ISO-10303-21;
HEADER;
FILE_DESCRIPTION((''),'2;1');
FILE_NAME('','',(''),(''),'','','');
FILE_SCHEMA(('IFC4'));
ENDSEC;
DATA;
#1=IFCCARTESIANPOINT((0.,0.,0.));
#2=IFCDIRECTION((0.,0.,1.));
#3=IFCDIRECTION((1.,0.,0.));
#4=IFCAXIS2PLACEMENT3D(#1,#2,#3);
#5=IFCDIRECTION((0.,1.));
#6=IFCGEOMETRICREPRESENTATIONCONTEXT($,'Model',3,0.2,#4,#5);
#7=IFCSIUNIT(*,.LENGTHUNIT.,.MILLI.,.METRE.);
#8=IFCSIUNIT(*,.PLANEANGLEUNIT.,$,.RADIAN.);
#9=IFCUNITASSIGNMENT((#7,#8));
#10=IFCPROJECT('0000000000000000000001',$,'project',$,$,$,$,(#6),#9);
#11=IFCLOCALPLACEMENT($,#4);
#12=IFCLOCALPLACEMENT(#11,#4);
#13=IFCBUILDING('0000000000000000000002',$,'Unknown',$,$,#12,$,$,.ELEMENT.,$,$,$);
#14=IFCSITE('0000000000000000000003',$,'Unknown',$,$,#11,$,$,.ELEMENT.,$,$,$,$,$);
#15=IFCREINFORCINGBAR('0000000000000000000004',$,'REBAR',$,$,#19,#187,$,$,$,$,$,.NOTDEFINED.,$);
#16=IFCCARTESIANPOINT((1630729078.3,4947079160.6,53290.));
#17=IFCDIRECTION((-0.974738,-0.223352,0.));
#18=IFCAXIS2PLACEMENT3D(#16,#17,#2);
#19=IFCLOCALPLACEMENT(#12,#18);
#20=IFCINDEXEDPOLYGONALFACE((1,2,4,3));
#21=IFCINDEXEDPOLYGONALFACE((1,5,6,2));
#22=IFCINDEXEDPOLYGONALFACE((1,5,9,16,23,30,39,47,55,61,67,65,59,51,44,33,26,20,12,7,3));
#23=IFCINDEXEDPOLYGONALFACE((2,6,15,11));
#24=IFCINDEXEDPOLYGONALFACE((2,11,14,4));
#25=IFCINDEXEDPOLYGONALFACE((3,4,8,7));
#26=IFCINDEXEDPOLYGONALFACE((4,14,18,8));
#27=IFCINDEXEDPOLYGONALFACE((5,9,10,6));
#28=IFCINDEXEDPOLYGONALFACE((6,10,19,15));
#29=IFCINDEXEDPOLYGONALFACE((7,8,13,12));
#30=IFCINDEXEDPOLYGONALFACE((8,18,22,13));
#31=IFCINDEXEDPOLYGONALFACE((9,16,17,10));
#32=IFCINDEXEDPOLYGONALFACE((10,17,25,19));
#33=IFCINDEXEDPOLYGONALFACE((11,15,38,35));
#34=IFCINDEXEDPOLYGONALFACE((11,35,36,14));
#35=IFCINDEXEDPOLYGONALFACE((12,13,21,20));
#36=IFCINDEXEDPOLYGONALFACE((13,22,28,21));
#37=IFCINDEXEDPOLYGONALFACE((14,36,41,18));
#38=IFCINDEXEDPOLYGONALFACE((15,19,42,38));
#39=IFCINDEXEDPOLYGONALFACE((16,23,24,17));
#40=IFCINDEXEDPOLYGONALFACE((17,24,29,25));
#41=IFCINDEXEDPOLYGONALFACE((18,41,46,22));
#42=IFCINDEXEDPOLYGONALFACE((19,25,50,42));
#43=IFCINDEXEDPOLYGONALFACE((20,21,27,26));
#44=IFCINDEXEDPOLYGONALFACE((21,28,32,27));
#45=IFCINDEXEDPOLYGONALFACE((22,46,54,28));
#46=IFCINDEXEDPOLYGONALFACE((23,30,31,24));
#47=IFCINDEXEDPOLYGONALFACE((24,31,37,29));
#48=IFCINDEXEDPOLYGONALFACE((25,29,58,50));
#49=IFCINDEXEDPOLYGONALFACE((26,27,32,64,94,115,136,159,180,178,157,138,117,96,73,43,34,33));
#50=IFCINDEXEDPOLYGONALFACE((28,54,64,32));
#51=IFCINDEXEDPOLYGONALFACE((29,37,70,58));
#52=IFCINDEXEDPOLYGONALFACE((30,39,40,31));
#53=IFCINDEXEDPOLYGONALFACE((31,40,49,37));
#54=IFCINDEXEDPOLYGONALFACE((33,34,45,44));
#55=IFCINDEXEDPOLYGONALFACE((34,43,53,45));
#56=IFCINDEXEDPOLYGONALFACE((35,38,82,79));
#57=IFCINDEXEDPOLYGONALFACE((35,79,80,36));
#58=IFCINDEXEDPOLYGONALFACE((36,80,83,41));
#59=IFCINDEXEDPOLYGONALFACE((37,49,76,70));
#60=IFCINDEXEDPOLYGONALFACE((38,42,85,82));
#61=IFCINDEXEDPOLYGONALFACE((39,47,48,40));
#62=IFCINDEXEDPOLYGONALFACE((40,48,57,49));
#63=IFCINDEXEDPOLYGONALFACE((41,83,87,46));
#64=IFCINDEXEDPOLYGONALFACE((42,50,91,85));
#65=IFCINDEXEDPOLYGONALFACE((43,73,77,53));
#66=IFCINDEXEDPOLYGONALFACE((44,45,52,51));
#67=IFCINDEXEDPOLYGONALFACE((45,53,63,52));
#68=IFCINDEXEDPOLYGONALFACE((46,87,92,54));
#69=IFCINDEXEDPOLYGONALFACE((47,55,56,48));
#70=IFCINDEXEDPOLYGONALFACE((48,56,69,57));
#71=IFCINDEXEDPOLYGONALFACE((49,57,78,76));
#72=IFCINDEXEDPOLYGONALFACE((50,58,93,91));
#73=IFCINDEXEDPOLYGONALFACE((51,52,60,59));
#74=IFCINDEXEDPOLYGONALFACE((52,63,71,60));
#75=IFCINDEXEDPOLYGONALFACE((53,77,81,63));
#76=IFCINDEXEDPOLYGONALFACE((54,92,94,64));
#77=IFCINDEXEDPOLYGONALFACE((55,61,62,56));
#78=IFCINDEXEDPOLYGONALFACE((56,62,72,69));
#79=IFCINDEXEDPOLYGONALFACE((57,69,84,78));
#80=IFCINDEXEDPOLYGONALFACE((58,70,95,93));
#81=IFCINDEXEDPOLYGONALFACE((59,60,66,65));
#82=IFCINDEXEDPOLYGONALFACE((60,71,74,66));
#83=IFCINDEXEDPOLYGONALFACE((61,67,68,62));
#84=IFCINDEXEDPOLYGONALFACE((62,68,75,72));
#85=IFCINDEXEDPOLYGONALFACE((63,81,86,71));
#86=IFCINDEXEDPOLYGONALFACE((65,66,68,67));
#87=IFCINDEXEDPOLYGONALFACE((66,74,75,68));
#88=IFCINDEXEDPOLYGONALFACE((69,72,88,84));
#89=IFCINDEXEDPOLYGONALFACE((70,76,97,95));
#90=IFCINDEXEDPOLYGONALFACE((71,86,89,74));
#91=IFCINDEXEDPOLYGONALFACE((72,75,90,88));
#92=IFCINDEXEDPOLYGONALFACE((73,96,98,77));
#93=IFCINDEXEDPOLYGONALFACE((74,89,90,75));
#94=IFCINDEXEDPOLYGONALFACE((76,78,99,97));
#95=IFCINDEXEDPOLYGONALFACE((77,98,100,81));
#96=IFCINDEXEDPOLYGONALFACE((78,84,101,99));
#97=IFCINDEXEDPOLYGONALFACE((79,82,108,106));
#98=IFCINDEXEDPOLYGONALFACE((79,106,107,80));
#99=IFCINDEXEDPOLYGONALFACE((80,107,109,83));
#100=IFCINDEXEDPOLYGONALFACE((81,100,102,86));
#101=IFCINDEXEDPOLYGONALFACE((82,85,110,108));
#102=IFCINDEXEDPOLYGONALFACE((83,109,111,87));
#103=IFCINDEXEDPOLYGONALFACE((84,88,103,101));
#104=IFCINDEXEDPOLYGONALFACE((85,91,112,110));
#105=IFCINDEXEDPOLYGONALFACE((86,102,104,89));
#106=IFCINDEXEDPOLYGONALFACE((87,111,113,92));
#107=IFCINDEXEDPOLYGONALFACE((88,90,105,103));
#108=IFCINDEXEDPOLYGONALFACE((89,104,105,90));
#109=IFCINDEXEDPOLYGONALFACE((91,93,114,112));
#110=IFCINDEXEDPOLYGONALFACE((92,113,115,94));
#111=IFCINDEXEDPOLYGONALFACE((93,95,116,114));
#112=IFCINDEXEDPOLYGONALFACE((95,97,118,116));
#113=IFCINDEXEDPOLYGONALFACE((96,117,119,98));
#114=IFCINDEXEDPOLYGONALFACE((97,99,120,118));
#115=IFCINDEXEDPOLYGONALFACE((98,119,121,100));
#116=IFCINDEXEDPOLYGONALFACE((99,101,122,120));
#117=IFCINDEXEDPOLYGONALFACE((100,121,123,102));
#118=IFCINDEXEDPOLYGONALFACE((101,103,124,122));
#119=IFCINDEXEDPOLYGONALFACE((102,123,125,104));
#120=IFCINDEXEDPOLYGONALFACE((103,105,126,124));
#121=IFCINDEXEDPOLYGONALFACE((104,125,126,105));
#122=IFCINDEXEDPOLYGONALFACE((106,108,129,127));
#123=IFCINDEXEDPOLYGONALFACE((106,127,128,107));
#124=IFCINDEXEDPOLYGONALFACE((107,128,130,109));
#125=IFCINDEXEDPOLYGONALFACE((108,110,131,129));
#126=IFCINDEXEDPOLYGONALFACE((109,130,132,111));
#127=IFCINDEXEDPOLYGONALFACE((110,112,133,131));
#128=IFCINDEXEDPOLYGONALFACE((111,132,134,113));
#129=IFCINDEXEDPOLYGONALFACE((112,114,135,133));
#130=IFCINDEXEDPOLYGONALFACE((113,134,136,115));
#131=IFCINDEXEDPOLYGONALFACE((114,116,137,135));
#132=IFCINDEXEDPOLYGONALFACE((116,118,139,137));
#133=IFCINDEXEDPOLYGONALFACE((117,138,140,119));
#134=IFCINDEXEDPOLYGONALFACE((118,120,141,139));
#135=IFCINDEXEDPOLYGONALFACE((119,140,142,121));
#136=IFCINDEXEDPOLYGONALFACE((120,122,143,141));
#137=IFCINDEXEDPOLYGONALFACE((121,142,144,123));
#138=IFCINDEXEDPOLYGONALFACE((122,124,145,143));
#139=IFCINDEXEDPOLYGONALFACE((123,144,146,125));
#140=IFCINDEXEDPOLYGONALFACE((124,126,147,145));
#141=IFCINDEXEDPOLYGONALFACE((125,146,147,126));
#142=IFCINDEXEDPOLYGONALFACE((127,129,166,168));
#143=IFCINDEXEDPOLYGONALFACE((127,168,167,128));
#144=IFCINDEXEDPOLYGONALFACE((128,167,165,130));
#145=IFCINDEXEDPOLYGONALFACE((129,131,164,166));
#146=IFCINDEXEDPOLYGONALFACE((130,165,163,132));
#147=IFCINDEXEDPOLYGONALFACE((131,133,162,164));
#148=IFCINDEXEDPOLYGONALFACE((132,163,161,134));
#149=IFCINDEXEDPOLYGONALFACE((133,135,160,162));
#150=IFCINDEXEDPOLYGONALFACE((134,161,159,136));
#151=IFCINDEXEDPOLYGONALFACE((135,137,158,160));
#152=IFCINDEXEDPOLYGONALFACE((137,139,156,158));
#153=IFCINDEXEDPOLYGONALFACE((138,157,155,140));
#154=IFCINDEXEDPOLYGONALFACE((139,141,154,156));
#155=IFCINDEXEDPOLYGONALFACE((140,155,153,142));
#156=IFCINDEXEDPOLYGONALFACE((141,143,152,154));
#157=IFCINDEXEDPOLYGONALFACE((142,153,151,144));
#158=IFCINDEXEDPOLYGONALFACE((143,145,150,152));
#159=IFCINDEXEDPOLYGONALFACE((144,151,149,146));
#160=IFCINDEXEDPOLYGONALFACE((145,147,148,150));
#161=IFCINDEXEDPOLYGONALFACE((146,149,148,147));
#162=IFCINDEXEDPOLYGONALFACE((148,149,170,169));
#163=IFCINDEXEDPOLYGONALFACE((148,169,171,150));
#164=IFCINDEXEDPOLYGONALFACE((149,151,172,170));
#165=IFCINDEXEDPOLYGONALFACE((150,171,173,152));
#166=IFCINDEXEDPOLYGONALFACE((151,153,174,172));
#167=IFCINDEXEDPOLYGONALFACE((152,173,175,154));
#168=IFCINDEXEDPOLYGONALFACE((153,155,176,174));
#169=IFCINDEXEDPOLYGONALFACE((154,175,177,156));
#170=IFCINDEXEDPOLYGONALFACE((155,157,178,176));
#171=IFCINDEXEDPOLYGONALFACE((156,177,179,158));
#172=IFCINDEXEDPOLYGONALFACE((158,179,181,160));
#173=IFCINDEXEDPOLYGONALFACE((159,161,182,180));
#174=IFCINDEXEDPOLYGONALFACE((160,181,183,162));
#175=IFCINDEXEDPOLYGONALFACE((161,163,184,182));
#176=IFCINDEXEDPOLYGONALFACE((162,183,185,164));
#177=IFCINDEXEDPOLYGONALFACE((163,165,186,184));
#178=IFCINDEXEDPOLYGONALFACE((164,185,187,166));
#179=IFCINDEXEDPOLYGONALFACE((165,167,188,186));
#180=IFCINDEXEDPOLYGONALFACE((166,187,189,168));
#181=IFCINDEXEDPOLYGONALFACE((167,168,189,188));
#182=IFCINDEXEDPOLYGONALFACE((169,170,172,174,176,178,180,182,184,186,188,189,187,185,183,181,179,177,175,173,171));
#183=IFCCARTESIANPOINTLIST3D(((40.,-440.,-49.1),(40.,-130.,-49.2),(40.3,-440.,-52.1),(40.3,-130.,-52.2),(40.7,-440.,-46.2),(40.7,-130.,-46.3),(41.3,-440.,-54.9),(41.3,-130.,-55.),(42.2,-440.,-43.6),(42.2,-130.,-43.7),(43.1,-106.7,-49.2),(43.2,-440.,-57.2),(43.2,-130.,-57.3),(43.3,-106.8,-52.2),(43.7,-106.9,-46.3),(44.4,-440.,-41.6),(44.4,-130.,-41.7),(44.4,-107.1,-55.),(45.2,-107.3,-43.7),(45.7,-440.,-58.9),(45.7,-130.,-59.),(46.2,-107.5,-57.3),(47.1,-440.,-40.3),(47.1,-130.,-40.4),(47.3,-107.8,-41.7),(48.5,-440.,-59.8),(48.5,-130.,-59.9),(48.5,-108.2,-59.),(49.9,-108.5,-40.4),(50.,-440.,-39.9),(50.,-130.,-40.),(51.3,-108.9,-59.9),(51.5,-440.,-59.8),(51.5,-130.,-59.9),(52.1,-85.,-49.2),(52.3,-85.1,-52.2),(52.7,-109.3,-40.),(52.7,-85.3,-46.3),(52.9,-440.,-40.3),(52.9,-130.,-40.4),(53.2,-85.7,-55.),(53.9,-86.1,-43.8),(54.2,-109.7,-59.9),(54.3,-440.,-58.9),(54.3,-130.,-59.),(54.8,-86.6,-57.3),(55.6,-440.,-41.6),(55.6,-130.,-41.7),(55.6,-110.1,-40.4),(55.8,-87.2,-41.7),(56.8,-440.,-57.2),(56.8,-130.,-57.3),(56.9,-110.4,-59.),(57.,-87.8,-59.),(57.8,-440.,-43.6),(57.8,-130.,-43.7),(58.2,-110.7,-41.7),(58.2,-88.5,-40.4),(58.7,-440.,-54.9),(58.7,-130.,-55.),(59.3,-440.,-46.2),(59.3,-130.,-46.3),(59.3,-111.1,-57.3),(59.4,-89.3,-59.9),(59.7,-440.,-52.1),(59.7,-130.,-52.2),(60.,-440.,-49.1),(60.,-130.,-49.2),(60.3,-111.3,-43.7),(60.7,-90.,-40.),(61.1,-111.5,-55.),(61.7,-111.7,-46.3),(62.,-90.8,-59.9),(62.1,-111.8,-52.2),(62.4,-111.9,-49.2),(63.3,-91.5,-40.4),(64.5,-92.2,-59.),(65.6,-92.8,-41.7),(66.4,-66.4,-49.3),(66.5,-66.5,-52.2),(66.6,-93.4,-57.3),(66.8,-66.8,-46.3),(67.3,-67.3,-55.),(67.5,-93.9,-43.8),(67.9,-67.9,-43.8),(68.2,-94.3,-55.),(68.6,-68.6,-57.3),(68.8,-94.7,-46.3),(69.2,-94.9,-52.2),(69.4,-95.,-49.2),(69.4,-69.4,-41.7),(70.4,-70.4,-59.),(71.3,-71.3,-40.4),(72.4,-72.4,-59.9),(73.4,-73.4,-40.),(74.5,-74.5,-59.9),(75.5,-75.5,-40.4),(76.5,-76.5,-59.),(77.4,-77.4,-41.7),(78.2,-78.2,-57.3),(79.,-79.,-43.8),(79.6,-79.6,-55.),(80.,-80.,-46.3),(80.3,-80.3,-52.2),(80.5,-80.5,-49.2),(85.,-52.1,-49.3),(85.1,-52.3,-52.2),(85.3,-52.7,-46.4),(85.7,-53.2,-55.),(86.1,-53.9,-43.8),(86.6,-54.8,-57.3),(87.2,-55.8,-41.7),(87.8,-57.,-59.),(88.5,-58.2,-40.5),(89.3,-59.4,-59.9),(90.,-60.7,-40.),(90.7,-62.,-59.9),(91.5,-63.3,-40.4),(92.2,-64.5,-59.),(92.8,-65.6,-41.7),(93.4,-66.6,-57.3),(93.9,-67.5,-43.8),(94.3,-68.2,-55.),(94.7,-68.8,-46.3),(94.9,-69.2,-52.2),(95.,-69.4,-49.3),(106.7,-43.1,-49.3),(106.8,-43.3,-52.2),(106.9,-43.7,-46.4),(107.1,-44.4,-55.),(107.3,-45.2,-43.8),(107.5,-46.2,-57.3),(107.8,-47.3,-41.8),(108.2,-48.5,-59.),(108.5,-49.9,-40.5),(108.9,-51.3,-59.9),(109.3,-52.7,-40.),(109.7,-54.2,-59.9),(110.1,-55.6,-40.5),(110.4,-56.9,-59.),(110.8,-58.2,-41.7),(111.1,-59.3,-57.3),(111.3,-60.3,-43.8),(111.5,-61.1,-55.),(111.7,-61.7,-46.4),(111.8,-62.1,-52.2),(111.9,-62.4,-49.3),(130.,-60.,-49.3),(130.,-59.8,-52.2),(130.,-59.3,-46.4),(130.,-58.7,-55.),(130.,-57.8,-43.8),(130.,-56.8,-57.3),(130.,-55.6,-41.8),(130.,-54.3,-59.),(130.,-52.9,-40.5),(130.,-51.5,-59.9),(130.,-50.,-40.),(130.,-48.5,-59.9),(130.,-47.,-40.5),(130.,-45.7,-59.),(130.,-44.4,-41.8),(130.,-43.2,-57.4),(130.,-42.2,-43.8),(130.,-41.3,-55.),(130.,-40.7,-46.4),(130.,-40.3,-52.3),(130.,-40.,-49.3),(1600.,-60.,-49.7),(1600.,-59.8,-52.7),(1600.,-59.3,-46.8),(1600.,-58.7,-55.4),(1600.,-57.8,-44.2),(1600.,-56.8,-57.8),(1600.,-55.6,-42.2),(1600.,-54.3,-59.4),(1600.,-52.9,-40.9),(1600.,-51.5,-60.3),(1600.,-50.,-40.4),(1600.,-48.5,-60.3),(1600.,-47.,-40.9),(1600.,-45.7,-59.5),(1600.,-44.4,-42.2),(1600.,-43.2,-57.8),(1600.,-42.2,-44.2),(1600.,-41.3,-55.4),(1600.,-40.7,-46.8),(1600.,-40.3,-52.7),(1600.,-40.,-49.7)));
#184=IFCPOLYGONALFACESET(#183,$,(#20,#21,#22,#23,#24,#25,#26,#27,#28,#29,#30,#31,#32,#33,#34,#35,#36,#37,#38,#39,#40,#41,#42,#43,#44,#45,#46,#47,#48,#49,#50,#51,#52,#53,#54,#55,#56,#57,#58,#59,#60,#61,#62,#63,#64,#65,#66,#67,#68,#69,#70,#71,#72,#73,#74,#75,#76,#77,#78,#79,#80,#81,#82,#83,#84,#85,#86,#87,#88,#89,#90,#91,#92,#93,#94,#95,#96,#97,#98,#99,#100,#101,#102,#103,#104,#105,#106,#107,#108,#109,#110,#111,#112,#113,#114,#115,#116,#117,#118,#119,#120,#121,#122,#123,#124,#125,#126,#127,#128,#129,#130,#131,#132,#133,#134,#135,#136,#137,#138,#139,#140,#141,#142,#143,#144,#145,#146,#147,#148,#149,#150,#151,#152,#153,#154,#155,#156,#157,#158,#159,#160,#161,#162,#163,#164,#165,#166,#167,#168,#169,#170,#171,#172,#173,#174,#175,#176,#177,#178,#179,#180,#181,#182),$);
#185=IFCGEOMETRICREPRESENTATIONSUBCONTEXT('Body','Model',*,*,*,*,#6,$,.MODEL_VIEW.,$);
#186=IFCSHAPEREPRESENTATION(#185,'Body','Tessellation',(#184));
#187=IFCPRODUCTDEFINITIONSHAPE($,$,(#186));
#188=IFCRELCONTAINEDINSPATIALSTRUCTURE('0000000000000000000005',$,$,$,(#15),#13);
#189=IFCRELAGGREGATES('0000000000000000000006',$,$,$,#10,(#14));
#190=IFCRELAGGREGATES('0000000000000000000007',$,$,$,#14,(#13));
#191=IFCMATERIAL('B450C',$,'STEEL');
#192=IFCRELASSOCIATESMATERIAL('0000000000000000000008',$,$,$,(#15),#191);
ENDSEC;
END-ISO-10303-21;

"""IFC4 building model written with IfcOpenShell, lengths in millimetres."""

from ifc_helpers import new_model, entity, si_unit, direction, frame, origin_with_axes, place, context, subcontext, project, spatial, material, element, save


model = new_model("IFC4")

# Units and contexts
model_context = context("Model", 3, precision=0.2, world=origin_with_axes(), true_north=direction((0.0, 1.0)))
body_context = subcontext(model_context, "Body", "Model", "MODEL_VIEW")
ifc_project = project(units=[si_unit("LENGTHUNIT", "METRE", prefix="MILLI"), si_unit("PLANEANGLEUNIT", "RADIAN")], contexts=[model_context])

# Site, building
site_placement = place(None, origin_with_axes())
site = spatial("IfcSite", under=ifc_project, at=site_placement, Name="Unknown", CompositionType="ELEMENT")
building_placement = place(site_placement, origin_with_axes())
building = spatial("IfcBuilding", under=site, at=building_placement, Name="Unknown", CompositionType="ELEMENT")

# Reinforcing bar
ifc_material = material(Name="B450C", Category="STEEL")
reinforcing_bar_1_placement = place(building_placement, frame((1630729078.3, 4947079160.6, 53290.0), z_axis=(-0.974738, -0.223352, 0.0), x_axis=(0.0, 0.0, 1.0)))
element("IfcReinforcingBar", 1, at=reinforcing_bar_1_placement, inside=building, material=ifc_material, Name="REBAR", PredefinedType="NOTDEFINED", context=body_context, shape_type="AdvancedSweptSolid", body=[
    entity("IfcSweptDiskSolid", entity("IfcIndexedPolyCurve", entity("IfcCartesianPointList3D", [[50.0, -440.0, -49.9], [50.0, -130.0, -50.0], [73.4, -73.4, -50.0], [130.0, -50.0, -50.0], [1600.0, -50.0, -50.4]]), [entity("IfcLineIndex", [1, 2]), entity("IfcArcIndex", [2, 3, 4]), entity("IfcLineIndex", [4, 5])]), 10.0),
])

save(model, "model.ifc")
